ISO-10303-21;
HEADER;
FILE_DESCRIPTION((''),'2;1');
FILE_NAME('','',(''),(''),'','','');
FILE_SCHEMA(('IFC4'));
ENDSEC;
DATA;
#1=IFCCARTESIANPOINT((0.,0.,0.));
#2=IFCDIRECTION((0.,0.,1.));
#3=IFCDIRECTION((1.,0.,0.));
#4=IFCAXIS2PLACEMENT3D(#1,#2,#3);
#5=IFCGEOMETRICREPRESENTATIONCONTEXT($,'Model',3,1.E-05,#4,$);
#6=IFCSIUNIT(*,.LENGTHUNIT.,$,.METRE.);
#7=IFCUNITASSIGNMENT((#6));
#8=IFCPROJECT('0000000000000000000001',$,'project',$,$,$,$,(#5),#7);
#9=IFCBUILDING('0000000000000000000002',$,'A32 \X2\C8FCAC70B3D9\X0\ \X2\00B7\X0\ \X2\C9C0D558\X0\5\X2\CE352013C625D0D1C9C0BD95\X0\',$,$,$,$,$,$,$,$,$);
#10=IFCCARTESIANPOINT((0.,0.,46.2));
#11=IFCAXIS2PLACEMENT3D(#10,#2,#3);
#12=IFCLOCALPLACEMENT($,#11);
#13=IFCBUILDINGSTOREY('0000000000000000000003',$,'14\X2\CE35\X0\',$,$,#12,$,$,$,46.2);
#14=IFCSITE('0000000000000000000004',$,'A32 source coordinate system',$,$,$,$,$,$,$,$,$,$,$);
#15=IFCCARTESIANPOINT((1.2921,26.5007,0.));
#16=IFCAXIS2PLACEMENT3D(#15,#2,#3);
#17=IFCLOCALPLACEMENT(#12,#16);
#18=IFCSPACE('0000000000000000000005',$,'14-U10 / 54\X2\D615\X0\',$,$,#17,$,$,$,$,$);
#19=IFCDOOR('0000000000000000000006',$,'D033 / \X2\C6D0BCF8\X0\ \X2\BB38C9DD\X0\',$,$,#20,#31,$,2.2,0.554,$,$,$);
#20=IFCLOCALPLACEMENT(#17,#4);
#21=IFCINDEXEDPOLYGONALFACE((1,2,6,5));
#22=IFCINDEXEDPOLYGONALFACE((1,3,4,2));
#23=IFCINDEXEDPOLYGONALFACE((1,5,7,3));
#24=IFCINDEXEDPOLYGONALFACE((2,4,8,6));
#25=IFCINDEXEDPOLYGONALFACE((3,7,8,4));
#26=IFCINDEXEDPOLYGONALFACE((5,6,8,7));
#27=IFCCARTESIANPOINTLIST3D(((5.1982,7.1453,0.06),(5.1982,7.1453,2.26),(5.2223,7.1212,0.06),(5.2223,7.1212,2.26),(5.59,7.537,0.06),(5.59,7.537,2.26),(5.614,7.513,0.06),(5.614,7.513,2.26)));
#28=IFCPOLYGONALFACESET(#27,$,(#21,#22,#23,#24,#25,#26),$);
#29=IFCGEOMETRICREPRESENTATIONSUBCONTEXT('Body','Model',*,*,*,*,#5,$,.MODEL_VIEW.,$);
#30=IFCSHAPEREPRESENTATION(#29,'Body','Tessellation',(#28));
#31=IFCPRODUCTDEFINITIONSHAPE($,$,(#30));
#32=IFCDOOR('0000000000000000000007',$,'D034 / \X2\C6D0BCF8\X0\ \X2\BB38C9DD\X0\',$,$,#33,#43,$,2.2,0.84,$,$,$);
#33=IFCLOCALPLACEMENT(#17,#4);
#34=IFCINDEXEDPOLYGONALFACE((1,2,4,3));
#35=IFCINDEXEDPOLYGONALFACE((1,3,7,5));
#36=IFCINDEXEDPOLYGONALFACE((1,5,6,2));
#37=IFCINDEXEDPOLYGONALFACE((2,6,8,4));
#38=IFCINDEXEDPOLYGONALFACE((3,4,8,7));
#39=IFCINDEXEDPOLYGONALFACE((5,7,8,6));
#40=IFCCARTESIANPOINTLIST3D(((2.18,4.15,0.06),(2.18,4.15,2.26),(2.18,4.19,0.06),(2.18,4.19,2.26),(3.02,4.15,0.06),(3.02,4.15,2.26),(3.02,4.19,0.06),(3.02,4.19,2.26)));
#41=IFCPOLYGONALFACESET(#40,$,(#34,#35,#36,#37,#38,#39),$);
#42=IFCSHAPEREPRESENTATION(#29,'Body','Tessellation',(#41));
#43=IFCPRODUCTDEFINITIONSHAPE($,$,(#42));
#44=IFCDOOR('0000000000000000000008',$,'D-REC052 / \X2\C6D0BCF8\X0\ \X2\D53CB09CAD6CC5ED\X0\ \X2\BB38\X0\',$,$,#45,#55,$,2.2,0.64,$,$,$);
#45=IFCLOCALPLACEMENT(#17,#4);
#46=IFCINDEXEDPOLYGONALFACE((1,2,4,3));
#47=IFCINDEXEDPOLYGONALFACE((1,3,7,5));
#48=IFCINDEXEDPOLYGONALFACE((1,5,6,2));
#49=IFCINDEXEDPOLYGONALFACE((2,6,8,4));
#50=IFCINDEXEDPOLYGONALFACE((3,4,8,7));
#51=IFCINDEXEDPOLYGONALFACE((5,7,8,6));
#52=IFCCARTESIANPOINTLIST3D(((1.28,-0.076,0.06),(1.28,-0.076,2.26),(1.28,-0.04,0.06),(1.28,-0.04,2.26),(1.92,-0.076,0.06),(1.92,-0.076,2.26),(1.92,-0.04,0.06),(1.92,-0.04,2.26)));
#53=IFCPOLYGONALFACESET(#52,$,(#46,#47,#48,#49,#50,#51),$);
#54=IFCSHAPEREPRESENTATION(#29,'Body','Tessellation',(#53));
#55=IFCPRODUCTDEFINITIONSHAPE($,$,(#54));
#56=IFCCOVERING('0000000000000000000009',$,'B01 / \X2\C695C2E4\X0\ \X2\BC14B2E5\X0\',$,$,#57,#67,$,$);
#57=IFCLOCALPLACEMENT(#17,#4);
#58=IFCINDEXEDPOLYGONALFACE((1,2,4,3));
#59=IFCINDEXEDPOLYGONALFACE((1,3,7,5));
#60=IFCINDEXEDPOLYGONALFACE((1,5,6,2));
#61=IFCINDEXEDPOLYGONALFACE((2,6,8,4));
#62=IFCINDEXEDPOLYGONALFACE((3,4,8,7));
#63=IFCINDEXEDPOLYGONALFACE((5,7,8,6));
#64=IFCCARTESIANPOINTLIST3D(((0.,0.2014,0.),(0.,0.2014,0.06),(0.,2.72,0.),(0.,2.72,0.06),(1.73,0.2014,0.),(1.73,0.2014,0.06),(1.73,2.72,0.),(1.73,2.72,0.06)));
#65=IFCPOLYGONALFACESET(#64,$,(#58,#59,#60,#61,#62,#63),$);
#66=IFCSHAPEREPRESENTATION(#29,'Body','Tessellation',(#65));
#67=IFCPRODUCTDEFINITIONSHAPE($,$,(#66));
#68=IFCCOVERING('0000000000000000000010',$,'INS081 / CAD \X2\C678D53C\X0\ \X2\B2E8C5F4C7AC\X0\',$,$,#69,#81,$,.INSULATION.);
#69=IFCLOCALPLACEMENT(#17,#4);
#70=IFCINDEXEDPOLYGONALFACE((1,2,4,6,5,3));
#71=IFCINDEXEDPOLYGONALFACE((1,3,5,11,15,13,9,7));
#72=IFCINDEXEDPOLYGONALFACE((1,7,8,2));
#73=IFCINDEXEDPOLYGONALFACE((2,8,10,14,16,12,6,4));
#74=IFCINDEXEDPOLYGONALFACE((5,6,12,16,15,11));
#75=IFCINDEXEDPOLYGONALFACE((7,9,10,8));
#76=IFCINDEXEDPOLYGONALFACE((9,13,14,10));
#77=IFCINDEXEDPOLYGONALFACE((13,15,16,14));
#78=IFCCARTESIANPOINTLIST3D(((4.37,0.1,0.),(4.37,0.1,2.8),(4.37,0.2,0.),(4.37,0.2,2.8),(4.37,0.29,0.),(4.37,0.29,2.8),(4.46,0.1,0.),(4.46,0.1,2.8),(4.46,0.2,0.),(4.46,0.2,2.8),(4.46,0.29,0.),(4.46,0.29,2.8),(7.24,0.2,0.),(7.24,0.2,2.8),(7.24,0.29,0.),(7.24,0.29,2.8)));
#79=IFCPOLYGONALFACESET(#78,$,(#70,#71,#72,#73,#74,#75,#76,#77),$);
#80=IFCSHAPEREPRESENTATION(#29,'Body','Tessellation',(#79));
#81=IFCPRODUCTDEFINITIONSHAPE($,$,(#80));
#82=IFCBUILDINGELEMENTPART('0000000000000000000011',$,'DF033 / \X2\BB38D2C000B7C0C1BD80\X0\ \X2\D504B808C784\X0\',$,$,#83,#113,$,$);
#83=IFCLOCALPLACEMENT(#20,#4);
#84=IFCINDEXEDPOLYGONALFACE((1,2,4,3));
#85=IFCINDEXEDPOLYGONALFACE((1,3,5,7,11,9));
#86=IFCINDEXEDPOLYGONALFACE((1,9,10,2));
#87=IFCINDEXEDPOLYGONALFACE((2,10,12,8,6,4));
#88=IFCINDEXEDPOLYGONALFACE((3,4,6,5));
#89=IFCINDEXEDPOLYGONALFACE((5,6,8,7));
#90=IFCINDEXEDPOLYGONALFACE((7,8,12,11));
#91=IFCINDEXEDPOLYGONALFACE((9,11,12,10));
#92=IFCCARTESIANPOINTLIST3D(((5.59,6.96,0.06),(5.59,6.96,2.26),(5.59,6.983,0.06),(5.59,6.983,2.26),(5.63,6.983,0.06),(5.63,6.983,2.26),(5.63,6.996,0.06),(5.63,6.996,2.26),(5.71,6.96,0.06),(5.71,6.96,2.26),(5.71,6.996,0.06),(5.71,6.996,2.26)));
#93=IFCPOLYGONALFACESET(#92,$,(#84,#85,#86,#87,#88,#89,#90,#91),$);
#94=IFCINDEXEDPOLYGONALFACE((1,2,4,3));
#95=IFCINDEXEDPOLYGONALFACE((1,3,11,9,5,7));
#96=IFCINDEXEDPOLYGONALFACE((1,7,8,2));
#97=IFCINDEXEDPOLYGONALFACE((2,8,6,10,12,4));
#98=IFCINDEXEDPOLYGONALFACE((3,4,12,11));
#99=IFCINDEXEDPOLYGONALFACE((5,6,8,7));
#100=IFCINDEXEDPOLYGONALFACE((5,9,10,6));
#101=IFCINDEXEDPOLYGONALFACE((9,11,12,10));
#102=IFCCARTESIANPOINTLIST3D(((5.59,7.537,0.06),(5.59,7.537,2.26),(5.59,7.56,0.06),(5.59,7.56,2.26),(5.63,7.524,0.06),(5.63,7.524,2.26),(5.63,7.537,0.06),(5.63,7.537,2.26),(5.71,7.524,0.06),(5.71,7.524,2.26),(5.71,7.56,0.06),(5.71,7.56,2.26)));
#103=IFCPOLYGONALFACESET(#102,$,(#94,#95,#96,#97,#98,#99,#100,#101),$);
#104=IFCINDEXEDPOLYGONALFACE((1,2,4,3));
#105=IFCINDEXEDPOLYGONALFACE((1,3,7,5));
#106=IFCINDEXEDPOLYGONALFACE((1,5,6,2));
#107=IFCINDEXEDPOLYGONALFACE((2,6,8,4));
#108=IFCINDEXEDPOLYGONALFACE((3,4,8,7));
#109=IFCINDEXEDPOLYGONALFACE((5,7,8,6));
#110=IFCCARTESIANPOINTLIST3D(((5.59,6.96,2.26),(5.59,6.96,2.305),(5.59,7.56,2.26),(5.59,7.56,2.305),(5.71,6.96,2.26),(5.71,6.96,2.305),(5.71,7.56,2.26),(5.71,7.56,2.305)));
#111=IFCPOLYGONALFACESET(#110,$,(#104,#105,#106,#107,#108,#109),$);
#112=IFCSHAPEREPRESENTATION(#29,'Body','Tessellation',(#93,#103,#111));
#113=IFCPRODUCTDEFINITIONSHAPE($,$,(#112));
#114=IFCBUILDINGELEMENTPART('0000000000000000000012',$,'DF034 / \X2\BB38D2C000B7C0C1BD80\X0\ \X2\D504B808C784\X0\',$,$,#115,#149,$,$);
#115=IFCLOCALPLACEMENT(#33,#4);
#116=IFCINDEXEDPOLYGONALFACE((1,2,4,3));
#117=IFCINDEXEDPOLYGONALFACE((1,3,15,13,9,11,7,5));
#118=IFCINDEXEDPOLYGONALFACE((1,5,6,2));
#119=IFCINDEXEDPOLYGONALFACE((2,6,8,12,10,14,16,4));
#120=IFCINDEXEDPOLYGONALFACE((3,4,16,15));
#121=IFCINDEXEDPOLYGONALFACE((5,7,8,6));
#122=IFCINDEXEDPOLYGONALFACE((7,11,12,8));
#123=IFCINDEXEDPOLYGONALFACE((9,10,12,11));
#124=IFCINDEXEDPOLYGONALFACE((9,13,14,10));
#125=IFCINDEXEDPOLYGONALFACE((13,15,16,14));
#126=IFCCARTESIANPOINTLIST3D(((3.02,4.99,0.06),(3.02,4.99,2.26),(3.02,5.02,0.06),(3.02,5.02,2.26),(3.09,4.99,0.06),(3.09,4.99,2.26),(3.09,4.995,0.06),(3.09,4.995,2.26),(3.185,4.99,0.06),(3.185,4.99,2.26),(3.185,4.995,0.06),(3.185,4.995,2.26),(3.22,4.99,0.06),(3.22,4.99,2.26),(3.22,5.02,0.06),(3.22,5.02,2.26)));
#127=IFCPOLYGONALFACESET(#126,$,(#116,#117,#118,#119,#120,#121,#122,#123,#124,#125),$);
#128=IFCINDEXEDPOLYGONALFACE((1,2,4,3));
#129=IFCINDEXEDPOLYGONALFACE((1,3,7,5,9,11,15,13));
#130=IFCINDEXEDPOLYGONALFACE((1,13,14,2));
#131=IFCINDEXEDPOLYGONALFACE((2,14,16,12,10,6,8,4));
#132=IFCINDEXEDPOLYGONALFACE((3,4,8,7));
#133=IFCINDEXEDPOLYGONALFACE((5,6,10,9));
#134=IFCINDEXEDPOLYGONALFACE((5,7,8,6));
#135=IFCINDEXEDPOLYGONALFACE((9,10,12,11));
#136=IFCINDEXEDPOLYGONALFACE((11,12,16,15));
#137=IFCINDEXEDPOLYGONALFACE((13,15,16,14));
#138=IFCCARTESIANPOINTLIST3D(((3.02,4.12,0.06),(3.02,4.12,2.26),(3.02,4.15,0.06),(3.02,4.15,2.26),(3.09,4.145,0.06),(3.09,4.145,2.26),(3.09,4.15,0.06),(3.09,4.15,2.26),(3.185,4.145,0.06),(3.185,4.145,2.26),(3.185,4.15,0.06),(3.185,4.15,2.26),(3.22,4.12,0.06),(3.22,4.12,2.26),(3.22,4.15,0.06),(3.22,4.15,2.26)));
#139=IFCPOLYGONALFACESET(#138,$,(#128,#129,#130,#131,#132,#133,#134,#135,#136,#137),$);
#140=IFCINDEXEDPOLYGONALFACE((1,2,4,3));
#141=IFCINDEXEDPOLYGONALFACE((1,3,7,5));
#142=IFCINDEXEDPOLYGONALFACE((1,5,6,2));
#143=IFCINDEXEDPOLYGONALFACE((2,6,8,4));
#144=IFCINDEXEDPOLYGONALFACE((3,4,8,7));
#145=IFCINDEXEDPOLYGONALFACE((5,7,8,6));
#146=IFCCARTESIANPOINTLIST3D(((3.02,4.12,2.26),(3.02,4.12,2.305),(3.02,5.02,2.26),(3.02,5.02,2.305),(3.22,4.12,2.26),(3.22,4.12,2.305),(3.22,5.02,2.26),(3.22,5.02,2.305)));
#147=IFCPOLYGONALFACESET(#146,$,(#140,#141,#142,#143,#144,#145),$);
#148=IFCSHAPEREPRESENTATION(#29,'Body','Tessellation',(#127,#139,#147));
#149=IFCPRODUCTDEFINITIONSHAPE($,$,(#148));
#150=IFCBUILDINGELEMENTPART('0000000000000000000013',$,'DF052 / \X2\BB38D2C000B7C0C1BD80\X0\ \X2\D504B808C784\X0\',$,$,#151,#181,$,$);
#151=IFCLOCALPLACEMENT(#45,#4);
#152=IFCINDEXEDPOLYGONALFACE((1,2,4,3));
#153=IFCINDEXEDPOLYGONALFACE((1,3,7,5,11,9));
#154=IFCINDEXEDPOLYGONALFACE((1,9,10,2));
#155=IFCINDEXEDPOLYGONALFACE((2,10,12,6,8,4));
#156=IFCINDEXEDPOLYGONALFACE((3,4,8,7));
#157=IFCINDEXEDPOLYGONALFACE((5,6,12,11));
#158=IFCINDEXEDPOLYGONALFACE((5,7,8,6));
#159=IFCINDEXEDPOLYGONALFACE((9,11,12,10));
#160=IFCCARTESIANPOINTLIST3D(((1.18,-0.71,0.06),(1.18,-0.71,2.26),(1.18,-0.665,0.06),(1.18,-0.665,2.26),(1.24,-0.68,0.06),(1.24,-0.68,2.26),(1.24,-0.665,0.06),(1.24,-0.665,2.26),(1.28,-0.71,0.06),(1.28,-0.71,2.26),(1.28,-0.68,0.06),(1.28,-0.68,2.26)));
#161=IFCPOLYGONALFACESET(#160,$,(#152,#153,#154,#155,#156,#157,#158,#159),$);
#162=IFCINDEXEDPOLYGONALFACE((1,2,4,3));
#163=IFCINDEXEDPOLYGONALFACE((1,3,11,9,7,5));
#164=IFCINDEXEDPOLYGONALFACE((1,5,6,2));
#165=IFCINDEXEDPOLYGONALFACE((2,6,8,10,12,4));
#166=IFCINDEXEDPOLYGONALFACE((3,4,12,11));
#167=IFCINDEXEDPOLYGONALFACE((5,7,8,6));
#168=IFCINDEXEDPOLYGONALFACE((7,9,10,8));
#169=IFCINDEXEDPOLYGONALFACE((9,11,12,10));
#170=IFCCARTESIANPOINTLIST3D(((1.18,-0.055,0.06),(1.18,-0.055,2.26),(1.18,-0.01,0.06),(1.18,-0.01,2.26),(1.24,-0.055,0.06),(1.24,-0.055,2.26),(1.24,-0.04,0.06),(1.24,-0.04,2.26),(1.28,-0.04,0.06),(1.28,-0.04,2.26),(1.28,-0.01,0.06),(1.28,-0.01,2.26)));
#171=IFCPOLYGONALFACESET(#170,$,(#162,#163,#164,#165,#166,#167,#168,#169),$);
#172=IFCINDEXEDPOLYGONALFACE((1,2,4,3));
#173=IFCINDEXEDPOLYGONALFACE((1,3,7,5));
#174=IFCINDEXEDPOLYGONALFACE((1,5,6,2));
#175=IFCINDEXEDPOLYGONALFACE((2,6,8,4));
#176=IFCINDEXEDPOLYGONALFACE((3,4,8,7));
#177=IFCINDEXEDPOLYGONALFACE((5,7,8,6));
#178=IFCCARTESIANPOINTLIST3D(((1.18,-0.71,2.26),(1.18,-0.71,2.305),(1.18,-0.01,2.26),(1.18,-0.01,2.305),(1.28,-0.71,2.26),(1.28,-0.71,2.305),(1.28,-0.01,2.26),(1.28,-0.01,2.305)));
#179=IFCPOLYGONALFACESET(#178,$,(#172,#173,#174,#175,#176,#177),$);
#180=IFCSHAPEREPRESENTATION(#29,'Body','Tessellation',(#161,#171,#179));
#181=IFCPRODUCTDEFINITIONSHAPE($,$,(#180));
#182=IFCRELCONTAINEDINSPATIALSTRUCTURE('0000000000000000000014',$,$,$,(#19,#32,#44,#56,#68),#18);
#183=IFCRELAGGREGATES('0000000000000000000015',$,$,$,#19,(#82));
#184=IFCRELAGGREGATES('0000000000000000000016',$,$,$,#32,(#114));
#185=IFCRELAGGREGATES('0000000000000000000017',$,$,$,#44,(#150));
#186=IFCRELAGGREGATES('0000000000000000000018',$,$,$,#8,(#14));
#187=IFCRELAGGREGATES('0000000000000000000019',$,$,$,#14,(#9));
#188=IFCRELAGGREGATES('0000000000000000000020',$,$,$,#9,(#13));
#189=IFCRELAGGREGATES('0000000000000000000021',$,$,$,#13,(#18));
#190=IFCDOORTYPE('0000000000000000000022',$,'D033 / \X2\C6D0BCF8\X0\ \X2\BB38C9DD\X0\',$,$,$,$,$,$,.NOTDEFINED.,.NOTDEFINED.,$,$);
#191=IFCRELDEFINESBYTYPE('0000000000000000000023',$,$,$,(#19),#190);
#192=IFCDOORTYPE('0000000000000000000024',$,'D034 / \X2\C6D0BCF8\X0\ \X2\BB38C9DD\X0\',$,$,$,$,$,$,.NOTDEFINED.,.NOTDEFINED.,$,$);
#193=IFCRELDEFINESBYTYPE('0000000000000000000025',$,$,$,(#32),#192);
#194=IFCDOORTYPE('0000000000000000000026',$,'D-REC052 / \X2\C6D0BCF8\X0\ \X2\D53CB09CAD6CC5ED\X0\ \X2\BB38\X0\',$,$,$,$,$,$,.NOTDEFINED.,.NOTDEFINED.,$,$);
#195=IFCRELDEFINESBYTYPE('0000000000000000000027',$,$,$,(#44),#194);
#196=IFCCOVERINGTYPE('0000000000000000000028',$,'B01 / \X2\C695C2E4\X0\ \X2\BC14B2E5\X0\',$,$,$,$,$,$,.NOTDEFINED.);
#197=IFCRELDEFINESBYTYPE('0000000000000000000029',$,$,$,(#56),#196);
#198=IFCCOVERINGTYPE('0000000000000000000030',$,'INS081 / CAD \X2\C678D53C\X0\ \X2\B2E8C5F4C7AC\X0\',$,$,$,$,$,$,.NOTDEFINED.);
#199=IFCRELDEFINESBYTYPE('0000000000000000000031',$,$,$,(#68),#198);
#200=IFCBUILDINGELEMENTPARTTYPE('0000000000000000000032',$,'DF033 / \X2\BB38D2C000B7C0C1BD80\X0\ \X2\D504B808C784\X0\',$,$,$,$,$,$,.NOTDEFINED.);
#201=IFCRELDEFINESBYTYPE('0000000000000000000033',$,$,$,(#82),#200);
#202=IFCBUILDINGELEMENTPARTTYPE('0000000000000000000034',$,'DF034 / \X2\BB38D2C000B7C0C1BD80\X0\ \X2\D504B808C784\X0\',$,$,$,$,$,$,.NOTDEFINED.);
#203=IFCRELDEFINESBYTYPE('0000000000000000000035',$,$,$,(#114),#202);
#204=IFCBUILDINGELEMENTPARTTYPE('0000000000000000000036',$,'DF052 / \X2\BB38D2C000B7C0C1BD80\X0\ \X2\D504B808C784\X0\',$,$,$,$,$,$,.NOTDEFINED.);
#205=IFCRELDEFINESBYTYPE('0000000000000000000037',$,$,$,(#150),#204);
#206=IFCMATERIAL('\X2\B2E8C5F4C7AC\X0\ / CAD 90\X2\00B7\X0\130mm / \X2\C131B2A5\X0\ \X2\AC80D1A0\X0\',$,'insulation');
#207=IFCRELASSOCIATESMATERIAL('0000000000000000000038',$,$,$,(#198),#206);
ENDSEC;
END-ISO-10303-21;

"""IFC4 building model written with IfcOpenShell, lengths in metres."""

from ifc_helpers import new_model, si_unit, frame, origin, origin_with_axes, place, context, subcontext, project, spatial, polyline, outline, extrude, source, transform, mapped, material, type_object, type_shapes, element, aggregate, save


model = new_model("IFC4")

# Units and contexts
model_context = context("Model", 3, precision=1e-05, world=origin_with_axes())
body_context = subcontext(model_context, "Body", "Model", "MODEL_VIEW")
ifc_project = project(units=[si_unit("LENGTHUNIT", "METRE")], contexts=[model_context])

# Site, building, storey, space
storey_placement = place(None, frame((0.0, 0.0, 46.2), z_axis=(0.0, 0.0, 1.0), x_axis=(1.0, 0.0, 0.0)))
space_placement = place(storey_placement, frame((1.2921, 26.5007, 0.0), z_axis=(0.0, 0.0, 1.0), x_axis=(1.0, 0.0, 0.0)))
site = spatial("IfcSite", under=ifc_project, Name="A32 source coordinate system")
building = spatial("IfcBuilding", under=site, Name="A32 주거동 · 지하5층–옥탑지붕")
storey = spatial("IfcBuildingStorey", under=building, at=storey_placement, Name="14층", Elevation=46.2)
space = spatial("IfcSpace", under=storey, at=space_placement, Name="14-U10 / 54형")

# Doors
door_type_1 = type_object("IfcDoorType", Name="D033 / 원본 문짝", OperationType="NOTDEFINED", PredefinedType="NOTDEFINED")
shared_shape_1 = source(origin(), body_context, "Body", "SweptSolid", [
    extrude(outline(polyline([(5.2223, 7.1212), (5.1982, 7.1453), (5.59, 7.537), (5.614, 7.513), (5.2223, 7.1212)])), frame((0.0, 0.0, 0.06)), (0.0, 0.0, 1.0), 2.2),
])
type_shapes(door_type_1, [shared_shape_1])
door_1_placement = place(space_placement, origin_with_axes())
door_1 = element("IfcDoor", 1, at=door_1_placement, inside=space, type_object=door_type_1, Name="D033 / 원본 문짝", OverallHeight=2.2, OverallWidth=0.554, context=body_context, shape_type="MappedRepresentation", body=[
    mapped(shared_shape_1, transform((0.0, 0.0, 0.0), scale=1.0)),
])
door_type_2 = type_object("IfcDoorType", Name="D034 / 원본 문짝", OperationType="NOTDEFINED", PredefinedType="NOTDEFINED")
shared_shape_2 = source(origin(), body_context, "Body", "SweptSolid", [
    extrude(outline(polyline([(3.02, 4.15), (2.18, 4.15), (2.18, 4.19), (3.02, 4.19), (3.02, 4.15)])), frame((0.0, 0.0, 0.06)), (0.0, 0.0, 1.0), 2.2),
])
type_shapes(door_type_2, [shared_shape_2])
door_2_placement = place(space_placement, origin_with_axes())
door_2 = element("IfcDoor", 2, at=door_2_placement, inside=space, type_object=door_type_2, Name="D034 / 원본 문짝", OverallHeight=2.2, OverallWidth=0.84, context=body_context, shape_type="MappedRepresentation", body=[
    mapped(shared_shape_2, transform((0.0, 0.0, 0.0), scale=1.0)),
])
door_type_3 = type_object("IfcDoorType", Name="D-REC052 / 원본 피난구역 문", OperationType="NOTDEFINED", PredefinedType="NOTDEFINED")
shared_shape_3 = source(origin(), body_context, "Body", "SweptSolid", [
    extrude(outline(polyline([(1.92, -0.076), (1.28, -0.076), (1.28, -0.04), (1.92, -0.04), (1.92, -0.076)])), frame((0.0, 0.0, 0.06)), (0.0, 0.0, 1.0), 2.2),
])
type_shapes(door_type_3, [shared_shape_3])
door_3_placement = place(space_placement, origin_with_axes())
door_3 = element("IfcDoor", 3, at=door_3_placement, inside=space, type_object=door_type_3, Name="D-REC052 / 원본 피난구역 문", OverallHeight=2.2, OverallWidth=0.64, context=body_context, shape_type="MappedRepresentation", body=[
    mapped(shared_shape_3, transform((0.0, 0.0, 0.0), scale=1.0)),
])

# Coverings
covering_type_1 = type_object("IfcCoveringType", Name="B01 / 욕실 바닥", PredefinedType="NOTDEFINED")
shared_shape_4 = source(origin(), body_context, "Body", "SweptSolid", [
    extrude(outline(polyline([(0.0, 0.2014), (0.0, 2.72), (1.73, 2.72), (1.73, 0.2014), (0.0, 0.2014)])), origin(), (0.0, 0.0, 1.0), 0.06),
])
type_shapes(covering_type_1, [shared_shape_4])
covering_1_placement = place(space_placement, origin_with_axes())
element("IfcCovering", 4, at=covering_1_placement, inside=space, type_object=covering_type_1, Name="B01 / 욕실 바닥", context=body_context, shape_type="MappedRepresentation", body=[
    mapped(shared_shape_4, transform((0.0, 0.0, 0.0), scale=1.0)),
])
ifc_material = material(Name="단열재 / CAD 90·130mm / 성능 검토", Category="insulation")
covering_type_2 = type_object("IfcCoveringType", Name="INS081 / CAD 외피 단열재", PredefinedType="NOTDEFINED", material=ifc_material)
shared_shape_5 = source(origin(), body_context, "Body", "SweptSolid", [
    extrude(outline(polyline([(4.37, 0.2), (4.37, 0.29), (4.46, 0.29), (7.24, 0.29), (7.24, 0.2), (4.46, 0.2), (4.46, 0.1), (4.37, 0.1), (4.37, 0.2)])), origin(), (0.0, 0.0, 1.0), 2.8),
])
type_shapes(covering_type_2, [shared_shape_5])
covering_2_placement = place(space_placement, origin_with_axes())
element("IfcCovering", 5, at=covering_2_placement, inside=space, type_object=covering_type_2, Name="INS081 / CAD 외피 단열재", PredefinedType="INSULATION", context=body_context, shape_type="MappedRepresentation", body=[
    mapped(shared_shape_5, transform((0.0, 0.0, 0.0), scale=1.0)),
])

# Building element parts
building_element_part_type_1 = type_object("IfcBuildingElementPartType", Name="DF033 / 문틀·상부 프레임", PredefinedType="NOTDEFINED")
shared_shape_6 = source(origin(), body_context, "Body", "SweptSolid", [
    extrude(outline(polyline([(5.59, 6.96), (5.59, 6.983), (5.63, 6.983), (5.63, 6.996), (5.71, 6.996), (5.71, 6.96), (5.59, 6.96)])), frame((0.0, 0.0, 0.06)), (0.0, 0.0, 1.0), 2.2),
    extrude(outline(polyline([(5.71, 7.524), (5.63, 7.524), (5.63, 7.537), (5.59, 7.537), (5.59, 7.56), (5.71, 7.56), (5.71, 7.524)])), frame((0.0, 0.0, 0.06)), (0.0, 0.0, 1.0), 2.2),
    extrude(outline(polyline([(5.59, 6.96), (5.59, 7.56), (5.71, 7.56), (5.71, 6.96), (5.59, 6.96)])), frame((0.0, 0.0, 2.26)), (0.0, 0.0, 1.0), 0.045),
])
type_shapes(building_element_part_type_1, [shared_shape_6])
building_element_part_1_placement = place(door_1_placement, origin_with_axes())
building_element_part_1 = element("IfcBuildingElementPart", 6, at=building_element_part_1_placement, type_object=building_element_part_type_1, Name="DF033 / 문틀·상부 프레임", context=body_context, shape_type="MappedRepresentation", body=[
    mapped(shared_shape_6, transform((0.0, 0.0, 0.0), scale=1.0)),
])
aggregate(door_1, [building_element_part_1])
building_element_part_type_2 = type_object("IfcBuildingElementPartType", Name="DF034 / 문틀·상부 프레임", PredefinedType="NOTDEFINED")
shared_shape_7 = source(origin(), body_context, "Body", "SweptSolid", [
    extrude(outline(polyline([(3.22, 5.02), (3.22, 4.99), (3.185, 4.99), (3.185, 4.995), (3.09, 4.995), (3.09, 4.99), (3.02, 4.99), (3.02, 5.02), (3.22, 5.02)])), frame((0.0, 0.0, 0.06)), (0.0, 0.0, 1.0), 2.2),
    extrude(outline(polyline([(3.02, 4.15), (3.09, 4.15), (3.09, 4.145), (3.185, 4.145), (3.185, 4.15), (3.22, 4.15), (3.22, 4.12), (3.02, 4.12), (3.02, 4.15)])), frame((0.0, 0.0, 0.06)), (0.0, 0.0, 1.0), 2.2),
    extrude(outline(polyline([(3.02, 4.12), (3.02, 5.02), (3.22, 5.02), (3.22, 4.12), (3.02, 4.12)])), frame((0.0, 0.0, 2.26)), (0.0, 0.0, 1.0), 0.045),
])
type_shapes(building_element_part_type_2, [shared_shape_7])
building_element_part_2_placement = place(door_2_placement, origin_with_axes())
building_element_part_2 = element("IfcBuildingElementPart", 7, at=building_element_part_2_placement, type_object=building_element_part_type_2, Name="DF034 / 문틀·상부 프레임", context=body_context, shape_type="MappedRepresentation", body=[
    mapped(shared_shape_7, transform((0.0, 0.0, 0.0), scale=1.0)),
])
aggregate(door_2, [building_element_part_2])
building_element_part_type_3 = type_object("IfcBuildingElementPartType", Name="DF052 / 문틀·상부 프레임", PredefinedType="NOTDEFINED")
shared_shape_8 = source(origin(), body_context, "Body", "SweptSolid", [
    extrude(outline(polyline([(1.18, -0.71), (1.18, -0.665), (1.24, -0.665), (1.24, -0.68), (1.28, -0.68), (1.28, -0.71), (1.18, -0.71)])), frame((0.0, 0.0, 0.06)), (0.0, 0.0, 1.0), 2.2),
    extrude(outline(polyline([(1.28, -0.04), (1.24, -0.04), (1.24, -0.055), (1.18, -0.055), (1.18, -0.01), (1.28, -0.01), (1.28, -0.04)])), frame((0.0, 0.0, 0.06)), (0.0, 0.0, 1.0), 2.2),
    extrude(outline(polyline([(1.18, -0.71), (1.18, -0.01), (1.28, -0.01), (1.28, -0.71), (1.18, -0.71)])), frame((0.0, 0.0, 2.26)), (0.0, 0.0, 1.0), 0.045),
])
type_shapes(building_element_part_type_3, [shared_shape_8])
building_element_part_3_placement = place(door_3_placement, origin_with_axes())
building_element_part_3 = element("IfcBuildingElementPart", 8, at=building_element_part_3_placement, type_object=building_element_part_type_3, Name="DF052 / 문틀·상부 프레임", context=body_context, shape_type="MappedRepresentation", body=[
    mapped(shared_shape_8, transform((0.0, 0.0, 0.0), scale=1.0)),
])
aggregate(door_3, [building_element_part_3])

save(model, "model.ifc")
